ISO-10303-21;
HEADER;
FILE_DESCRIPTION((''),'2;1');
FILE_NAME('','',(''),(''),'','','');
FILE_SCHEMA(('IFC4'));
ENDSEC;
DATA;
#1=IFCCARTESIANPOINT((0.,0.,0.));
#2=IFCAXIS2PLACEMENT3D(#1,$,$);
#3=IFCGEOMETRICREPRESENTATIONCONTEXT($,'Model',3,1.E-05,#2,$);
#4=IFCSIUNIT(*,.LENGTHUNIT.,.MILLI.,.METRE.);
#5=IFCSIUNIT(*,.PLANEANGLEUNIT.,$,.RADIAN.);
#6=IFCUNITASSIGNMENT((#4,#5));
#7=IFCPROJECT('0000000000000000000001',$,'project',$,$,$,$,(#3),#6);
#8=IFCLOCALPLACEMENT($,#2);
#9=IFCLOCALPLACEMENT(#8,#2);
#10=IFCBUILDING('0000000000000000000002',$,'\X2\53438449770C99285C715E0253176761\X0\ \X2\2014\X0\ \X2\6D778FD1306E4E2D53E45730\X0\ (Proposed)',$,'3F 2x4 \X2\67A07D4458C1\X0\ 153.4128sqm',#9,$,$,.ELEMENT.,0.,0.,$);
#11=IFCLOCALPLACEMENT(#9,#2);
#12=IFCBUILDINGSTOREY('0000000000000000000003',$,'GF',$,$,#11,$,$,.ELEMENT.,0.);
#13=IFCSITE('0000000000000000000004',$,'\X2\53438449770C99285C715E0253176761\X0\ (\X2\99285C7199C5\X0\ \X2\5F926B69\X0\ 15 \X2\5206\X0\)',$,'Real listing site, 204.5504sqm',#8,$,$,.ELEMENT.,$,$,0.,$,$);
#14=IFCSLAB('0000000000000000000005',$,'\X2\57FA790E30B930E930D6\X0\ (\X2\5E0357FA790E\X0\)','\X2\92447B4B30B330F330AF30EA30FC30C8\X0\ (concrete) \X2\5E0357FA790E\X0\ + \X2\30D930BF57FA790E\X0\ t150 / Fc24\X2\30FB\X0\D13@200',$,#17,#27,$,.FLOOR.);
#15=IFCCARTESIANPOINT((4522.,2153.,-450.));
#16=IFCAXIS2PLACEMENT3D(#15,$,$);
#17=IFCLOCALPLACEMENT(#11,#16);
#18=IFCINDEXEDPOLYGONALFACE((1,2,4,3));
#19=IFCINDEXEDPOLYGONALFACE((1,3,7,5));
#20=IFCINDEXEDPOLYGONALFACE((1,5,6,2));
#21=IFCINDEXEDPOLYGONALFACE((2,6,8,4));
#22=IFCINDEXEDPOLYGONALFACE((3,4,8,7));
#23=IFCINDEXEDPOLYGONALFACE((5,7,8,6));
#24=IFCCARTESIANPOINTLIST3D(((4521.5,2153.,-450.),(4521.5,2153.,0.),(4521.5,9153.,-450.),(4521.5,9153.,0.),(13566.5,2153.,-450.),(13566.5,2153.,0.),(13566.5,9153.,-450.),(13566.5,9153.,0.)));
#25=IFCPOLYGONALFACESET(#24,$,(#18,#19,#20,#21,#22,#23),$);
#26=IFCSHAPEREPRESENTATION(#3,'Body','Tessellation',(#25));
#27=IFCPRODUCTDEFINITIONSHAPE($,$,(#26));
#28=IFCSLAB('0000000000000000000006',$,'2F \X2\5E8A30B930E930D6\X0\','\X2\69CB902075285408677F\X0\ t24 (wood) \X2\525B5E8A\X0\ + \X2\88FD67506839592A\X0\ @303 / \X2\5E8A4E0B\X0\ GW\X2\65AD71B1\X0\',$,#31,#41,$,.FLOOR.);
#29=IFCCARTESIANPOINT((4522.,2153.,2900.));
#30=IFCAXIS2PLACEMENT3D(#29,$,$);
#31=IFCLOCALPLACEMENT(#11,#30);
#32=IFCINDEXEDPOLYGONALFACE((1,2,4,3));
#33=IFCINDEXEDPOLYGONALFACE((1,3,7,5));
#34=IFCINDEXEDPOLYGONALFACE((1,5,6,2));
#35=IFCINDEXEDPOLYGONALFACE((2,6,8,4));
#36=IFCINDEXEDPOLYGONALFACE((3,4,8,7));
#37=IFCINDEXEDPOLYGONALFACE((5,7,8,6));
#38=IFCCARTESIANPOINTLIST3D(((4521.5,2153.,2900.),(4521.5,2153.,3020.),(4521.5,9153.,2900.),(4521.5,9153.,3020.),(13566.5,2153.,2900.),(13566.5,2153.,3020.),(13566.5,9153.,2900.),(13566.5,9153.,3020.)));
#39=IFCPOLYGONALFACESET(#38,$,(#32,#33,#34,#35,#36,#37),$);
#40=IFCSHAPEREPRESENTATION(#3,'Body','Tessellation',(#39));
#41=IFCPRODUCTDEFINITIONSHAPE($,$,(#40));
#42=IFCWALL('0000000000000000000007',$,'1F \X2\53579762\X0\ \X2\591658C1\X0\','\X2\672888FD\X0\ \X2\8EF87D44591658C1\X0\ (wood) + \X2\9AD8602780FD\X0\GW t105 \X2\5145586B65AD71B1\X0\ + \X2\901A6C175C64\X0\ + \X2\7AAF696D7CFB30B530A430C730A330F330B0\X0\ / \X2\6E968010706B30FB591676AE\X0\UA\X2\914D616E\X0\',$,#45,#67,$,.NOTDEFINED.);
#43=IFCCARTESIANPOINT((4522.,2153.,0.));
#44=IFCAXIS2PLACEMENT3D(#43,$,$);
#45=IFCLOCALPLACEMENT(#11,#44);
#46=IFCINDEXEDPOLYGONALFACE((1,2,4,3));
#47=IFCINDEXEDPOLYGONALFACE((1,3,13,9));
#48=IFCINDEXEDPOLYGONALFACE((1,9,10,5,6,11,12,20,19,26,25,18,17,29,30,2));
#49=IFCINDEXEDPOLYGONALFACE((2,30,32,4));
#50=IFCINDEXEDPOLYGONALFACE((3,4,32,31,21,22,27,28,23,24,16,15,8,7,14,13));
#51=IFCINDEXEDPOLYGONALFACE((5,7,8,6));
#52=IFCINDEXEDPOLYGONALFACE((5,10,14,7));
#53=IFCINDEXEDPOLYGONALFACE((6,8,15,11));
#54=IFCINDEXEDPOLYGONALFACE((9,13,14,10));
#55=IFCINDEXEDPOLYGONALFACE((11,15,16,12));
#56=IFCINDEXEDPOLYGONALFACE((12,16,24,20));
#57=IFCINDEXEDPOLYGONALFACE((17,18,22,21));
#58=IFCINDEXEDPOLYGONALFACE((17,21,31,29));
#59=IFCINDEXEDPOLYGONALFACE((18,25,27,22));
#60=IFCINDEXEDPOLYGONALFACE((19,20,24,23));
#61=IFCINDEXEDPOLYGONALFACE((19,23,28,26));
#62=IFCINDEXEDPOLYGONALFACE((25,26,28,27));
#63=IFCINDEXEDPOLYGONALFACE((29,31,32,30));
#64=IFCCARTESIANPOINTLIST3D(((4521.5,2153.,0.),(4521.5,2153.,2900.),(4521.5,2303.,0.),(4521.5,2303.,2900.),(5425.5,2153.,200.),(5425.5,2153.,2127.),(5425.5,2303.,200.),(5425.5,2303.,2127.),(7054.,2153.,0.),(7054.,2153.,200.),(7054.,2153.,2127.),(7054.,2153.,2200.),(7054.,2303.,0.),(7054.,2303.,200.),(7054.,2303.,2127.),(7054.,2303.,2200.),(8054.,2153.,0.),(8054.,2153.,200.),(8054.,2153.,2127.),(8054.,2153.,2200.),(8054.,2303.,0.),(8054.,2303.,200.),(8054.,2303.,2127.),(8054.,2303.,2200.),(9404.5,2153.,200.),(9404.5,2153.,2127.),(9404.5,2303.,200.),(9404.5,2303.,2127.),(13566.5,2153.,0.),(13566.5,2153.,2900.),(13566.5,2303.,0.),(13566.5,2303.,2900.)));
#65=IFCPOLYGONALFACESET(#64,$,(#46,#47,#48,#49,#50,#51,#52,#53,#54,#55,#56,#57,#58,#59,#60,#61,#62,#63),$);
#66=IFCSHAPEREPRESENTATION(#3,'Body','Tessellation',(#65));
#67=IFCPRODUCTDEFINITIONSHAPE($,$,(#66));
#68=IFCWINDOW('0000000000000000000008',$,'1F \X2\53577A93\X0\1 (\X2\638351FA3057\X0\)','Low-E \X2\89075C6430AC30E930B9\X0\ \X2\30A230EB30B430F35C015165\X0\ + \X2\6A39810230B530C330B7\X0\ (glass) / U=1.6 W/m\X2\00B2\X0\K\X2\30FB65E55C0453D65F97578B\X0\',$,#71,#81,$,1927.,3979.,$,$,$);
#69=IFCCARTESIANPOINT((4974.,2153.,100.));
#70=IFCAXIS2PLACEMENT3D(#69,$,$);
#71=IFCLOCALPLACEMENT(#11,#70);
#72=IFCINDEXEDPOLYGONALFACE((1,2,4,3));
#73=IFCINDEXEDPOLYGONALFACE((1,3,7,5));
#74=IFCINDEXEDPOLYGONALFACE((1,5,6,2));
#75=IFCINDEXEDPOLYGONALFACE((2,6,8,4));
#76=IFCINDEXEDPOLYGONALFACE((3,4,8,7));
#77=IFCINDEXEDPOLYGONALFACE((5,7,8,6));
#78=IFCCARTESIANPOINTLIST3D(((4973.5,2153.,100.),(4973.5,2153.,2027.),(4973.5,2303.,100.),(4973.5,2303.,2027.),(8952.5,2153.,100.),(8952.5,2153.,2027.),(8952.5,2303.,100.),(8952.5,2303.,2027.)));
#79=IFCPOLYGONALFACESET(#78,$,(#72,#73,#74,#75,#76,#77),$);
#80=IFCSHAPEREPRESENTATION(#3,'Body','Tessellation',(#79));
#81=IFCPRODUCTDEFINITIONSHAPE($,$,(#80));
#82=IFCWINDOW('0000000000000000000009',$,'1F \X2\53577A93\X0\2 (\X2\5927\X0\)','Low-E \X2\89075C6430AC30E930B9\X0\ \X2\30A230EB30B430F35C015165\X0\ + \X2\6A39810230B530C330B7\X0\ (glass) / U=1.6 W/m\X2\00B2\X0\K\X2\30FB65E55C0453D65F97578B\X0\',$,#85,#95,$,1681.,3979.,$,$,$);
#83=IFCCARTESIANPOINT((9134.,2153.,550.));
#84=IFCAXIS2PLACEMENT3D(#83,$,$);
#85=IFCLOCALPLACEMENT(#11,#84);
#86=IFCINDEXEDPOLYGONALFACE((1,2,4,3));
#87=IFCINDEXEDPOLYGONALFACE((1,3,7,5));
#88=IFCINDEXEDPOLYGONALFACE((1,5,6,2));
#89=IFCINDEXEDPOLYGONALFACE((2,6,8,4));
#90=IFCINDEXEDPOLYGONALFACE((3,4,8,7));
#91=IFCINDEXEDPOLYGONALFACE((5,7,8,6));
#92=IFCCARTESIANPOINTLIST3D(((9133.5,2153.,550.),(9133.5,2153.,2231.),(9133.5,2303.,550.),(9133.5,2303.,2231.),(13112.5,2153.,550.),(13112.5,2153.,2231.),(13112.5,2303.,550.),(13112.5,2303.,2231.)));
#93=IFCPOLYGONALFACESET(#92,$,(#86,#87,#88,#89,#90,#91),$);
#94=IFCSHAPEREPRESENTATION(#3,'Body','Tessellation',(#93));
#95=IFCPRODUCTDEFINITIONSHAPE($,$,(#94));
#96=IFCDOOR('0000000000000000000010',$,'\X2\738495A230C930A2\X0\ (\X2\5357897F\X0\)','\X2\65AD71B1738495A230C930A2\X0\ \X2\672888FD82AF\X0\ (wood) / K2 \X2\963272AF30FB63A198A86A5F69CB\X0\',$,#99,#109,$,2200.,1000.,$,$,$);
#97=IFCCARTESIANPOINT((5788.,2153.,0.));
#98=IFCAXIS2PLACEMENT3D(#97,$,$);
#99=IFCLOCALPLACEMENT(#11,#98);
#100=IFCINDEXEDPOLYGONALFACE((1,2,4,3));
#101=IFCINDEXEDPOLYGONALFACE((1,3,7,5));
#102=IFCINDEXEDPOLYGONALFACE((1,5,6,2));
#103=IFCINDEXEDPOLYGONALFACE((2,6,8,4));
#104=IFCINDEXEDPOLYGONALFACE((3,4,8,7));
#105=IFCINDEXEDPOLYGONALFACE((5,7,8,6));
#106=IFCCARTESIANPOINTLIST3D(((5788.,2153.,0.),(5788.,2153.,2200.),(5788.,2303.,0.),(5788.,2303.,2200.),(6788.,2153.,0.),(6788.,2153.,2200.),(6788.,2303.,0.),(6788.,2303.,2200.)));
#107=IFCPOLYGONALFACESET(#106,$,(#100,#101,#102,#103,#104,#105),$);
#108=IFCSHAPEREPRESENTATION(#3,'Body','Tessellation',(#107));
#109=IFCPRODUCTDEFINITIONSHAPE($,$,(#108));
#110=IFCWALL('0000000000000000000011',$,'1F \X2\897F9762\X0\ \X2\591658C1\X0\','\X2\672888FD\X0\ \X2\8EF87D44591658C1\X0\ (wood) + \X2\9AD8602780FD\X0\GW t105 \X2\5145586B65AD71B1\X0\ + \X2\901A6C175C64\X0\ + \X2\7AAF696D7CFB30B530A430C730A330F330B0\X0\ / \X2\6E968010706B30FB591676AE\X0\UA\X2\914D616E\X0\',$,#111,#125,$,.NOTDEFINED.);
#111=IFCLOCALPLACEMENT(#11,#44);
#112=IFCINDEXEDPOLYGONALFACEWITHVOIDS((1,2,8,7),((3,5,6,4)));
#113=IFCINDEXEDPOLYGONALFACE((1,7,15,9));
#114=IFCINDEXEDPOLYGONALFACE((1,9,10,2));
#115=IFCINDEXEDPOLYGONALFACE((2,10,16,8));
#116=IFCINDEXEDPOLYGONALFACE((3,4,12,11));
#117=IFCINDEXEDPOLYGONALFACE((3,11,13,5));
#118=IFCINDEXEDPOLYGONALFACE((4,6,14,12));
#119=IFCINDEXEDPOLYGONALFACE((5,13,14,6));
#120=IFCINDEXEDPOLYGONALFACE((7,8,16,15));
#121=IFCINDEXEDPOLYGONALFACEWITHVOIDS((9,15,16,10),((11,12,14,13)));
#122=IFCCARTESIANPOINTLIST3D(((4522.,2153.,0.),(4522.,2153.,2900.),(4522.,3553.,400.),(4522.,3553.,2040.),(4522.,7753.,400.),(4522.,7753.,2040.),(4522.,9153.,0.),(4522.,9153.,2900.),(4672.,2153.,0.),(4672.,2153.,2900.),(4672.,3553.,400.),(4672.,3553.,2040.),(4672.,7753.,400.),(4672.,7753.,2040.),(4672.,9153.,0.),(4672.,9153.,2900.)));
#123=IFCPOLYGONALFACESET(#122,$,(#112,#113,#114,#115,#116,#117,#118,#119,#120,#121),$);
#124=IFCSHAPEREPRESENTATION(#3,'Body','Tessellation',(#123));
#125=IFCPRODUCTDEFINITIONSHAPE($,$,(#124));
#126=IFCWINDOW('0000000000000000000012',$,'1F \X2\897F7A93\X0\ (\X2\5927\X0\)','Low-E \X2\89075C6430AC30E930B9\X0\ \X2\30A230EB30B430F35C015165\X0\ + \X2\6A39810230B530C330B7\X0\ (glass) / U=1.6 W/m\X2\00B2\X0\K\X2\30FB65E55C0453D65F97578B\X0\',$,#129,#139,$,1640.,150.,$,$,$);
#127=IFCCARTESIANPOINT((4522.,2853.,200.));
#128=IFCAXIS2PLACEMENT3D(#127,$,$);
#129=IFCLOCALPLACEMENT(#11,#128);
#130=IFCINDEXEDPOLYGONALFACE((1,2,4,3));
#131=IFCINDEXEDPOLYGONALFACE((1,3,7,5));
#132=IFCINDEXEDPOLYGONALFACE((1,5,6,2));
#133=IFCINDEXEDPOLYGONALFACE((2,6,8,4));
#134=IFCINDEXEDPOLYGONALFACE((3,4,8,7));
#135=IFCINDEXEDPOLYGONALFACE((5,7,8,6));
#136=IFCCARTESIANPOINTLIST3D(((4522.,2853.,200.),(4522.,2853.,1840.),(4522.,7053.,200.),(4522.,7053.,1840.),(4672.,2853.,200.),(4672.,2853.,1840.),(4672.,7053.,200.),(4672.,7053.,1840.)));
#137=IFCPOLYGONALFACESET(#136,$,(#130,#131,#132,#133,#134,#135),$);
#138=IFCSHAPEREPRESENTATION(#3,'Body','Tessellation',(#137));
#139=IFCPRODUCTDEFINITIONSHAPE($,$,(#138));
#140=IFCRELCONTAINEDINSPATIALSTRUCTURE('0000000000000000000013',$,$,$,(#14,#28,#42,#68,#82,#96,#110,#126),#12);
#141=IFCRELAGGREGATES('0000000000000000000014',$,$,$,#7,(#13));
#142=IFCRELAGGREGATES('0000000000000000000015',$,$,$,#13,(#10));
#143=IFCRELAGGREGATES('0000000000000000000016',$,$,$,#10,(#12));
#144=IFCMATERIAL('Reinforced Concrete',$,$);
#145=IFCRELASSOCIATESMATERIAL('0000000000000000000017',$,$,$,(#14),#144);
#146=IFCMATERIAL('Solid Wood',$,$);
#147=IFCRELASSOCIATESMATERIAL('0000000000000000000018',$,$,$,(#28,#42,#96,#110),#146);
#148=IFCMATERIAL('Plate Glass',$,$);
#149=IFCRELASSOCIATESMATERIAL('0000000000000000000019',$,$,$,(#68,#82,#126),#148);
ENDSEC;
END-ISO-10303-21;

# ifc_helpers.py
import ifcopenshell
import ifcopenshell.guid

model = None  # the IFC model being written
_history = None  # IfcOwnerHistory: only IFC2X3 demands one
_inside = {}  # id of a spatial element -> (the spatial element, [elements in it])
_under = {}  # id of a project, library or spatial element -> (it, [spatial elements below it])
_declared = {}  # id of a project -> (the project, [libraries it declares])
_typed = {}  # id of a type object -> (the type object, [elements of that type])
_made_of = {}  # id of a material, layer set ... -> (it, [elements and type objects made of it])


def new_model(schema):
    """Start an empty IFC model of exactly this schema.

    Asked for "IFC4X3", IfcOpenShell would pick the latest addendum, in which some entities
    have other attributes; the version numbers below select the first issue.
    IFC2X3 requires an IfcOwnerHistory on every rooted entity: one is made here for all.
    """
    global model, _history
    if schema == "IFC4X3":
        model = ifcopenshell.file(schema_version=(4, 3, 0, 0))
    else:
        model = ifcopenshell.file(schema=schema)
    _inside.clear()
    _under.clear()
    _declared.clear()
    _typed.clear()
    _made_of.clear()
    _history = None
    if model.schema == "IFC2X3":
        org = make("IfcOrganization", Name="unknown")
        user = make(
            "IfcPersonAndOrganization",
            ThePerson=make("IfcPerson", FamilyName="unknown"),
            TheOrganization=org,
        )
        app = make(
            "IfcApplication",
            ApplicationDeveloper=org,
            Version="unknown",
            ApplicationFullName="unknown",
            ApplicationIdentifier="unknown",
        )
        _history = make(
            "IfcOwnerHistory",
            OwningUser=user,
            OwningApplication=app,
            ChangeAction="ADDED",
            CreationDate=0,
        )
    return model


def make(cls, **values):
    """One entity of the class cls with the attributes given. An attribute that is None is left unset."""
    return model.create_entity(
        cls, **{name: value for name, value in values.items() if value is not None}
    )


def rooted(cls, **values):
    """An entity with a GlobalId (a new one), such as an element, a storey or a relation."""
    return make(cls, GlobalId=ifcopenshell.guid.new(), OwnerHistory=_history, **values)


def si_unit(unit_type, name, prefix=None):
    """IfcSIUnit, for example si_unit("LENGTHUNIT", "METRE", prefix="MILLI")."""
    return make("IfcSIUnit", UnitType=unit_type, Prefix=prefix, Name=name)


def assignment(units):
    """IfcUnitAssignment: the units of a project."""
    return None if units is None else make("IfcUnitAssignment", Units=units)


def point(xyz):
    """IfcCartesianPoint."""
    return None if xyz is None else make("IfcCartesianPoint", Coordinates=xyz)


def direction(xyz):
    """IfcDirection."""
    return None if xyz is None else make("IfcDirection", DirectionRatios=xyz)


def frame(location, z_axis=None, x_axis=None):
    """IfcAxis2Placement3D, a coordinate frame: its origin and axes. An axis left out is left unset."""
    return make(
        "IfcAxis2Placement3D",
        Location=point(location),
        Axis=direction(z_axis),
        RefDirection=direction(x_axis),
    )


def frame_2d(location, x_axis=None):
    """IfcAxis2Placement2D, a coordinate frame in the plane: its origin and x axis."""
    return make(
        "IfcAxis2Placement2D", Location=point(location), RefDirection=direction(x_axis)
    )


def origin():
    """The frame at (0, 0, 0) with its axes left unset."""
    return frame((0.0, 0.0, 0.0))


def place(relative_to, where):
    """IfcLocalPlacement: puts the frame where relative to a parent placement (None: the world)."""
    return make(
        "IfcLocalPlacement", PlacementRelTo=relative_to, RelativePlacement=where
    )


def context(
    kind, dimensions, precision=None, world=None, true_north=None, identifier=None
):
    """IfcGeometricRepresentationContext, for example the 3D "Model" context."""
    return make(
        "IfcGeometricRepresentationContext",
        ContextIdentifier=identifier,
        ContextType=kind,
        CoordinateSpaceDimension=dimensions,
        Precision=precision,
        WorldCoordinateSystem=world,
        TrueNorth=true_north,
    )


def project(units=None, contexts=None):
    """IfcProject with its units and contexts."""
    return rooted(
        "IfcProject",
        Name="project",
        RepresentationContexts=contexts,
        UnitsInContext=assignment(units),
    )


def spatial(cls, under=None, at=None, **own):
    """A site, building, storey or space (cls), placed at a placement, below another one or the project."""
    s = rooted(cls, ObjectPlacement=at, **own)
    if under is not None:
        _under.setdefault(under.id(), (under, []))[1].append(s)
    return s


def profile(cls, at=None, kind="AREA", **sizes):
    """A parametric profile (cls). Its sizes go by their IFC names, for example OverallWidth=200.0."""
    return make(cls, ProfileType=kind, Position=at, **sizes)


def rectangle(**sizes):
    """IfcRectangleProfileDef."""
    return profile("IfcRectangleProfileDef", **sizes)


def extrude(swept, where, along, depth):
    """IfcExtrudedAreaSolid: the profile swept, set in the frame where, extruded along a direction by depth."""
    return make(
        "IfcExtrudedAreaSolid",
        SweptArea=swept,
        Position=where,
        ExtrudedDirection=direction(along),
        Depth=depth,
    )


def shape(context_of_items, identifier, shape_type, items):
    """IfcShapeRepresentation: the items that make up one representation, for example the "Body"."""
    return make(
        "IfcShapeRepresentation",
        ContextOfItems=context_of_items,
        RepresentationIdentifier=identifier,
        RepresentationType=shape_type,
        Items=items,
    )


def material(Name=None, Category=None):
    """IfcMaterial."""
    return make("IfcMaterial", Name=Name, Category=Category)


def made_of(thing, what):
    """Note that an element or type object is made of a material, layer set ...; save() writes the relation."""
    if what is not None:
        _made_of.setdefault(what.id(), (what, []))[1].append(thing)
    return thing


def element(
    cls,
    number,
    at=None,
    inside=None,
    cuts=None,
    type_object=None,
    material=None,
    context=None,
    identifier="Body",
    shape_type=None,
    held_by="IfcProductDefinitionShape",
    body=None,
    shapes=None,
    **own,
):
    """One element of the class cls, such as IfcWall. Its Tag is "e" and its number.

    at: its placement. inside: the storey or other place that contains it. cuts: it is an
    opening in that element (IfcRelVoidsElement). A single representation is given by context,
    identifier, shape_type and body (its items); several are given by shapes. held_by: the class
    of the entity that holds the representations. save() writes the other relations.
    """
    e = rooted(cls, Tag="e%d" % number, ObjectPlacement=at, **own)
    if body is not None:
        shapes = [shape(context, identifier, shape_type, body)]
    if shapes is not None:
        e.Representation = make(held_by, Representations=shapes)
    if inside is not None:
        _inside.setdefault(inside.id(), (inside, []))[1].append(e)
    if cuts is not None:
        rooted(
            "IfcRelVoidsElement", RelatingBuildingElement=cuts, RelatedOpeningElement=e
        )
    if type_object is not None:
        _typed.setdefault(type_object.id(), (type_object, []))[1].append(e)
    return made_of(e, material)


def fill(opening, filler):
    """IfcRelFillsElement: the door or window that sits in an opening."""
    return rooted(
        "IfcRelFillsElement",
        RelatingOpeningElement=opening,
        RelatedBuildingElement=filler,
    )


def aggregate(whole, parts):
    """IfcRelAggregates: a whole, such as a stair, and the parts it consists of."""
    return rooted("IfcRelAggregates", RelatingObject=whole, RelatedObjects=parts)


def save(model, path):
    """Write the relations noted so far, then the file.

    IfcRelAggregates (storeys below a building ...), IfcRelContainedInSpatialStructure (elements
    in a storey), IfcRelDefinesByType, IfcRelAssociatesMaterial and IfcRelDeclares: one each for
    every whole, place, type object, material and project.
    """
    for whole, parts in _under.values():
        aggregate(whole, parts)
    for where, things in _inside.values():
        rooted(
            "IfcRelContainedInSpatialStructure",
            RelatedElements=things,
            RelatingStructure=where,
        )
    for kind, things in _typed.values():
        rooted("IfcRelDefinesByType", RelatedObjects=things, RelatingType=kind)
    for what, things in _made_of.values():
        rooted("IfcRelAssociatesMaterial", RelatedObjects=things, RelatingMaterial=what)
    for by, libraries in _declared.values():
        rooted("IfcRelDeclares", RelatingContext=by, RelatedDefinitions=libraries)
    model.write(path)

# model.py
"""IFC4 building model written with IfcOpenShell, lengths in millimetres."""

from ifc_helpers import new_model, si_unit, frame, frame_2d, origin, place, context, project, spatial, rectangle, extrude, material, element, fill, save


model = new_model("IFC4")

# Units and contexts
model_context = context("Model", 3, precision=1e-05, world=origin())
ifc_project = project(units=[si_unit("LENGTHUNIT", "METRE", prefix="MILLI"), si_unit("PLANEANGLEUNIT", "RADIAN")], contexts=[model_context])

# Site, building, storey
site_placement = place(None, origin())
site = spatial("IfcSite", under=ifc_project, at=site_placement, Name="千葉県館山市北条 (館山駅 徒歩 15 分)", ObjectType="Real listing site, 204.5504sqm", CompositionType="ELEMENT", RefElevation=0.0)
building_placement = place(site_placement, origin())
building = spatial("IfcBuilding", under=site, at=building_placement, Name="千葉県館山市北条 — 海近の中古地 (Proposed)", ObjectType="3F 2x4 枠組壁 153.4128sqm", CompositionType="ELEMENT", ElevationOfRefHeight=0.0, ElevationOfTerrain=0.0)
storey_placement = place(building_placement, origin())
storey = spatial("IfcBuildingStorey", under=building, at=storey_placement, Name="GF", CompositionType="ELEMENT", Elevation=0.0)

# Slabs
ifc_material_1 = material(Name="Reinforced Concrete")
slab_1_placement = place(storey_placement, frame((4522.0, 2153.0, -450.0)))
element("IfcSlab", 1, at=slab_1_placement, inside=storey, material=ifc_material_1, Name="基礎スラブ (布基礎)", Description="鉄筋コンクリート (concrete) 布基礎 + ベタ基礎 t150 / Fc24・D13@200", PredefinedType="FLOOR", context=model_context, shape_type="SweptSolid", body=[
    extrude(rectangle(XDim=9045.0, YDim=7000.0, at=frame_2d((4522.0, 3500.0))), frame((4522.0, 2153.0, -450.0)), (0.0, 0.0, 1.0), 450.0),
])
ifc_material_2 = material(Name="Solid Wood")
slab_2_placement = place(storey_placement, frame((4522.0, 2153.0, 2900.0)))
element("IfcSlab", 2, at=slab_2_placement, inside=storey, material=ifc_material_2, Name="2F 床スラブ", Description="構造用合板 t24 (wood) 剛床 + 製材根太 @303 / 床下 GW断熱", PredefinedType="FLOOR", context=model_context, shape_type="SweptSolid", body=[
    extrude(rectangle(XDim=9045.0, YDim=7000.0, at=frame_2d((4522.0, 3500.0))), frame((4522.0, 2153.0, 2900.0)), (0.0, 0.0, 1.0), 120.0),
])

# Wall, openings, windows, door
wall_1_placement = place(storey_placement, frame((4522.0, 2153.0, 0.0)))
wall_1 = element("IfcWall", 3, at=wall_1_placement, inside=storey, material=ifc_material_2, Name="1F 南面 外壁", Description="木製 軸組外壁 (wood) + 高性能GW t105 充填断熱 + 通気層 + 窯業系サイディング / 準耐火・外皮UA配慮", PredefinedType="NOTDEFINED", context=model_context, shape_type="SweptSolid", body=[
    extrude(rectangle(XDim=9045.0, YDim=150.0, at=frame_2d((4522.0, 75.0))), frame((4522.0, 2153.0, 0.0)), (0.0, 0.0, 1.0), 2900.0),
])
opening_1_placement = place(storey_placement, frame((4974.0, 2153.0, 100.0)))
opening_1 = element("IfcOpeningElement", 4, at=opening_1_placement, cuts=wall_1, PredefinedType="NOTDEFINED", context=model_context, shape_type="SweptSolid", body=[
    extrude(rectangle(XDim=3979.0, YDim=150.0, at=frame_2d((1989.0, 75.0))), frame((4974.0, 2153.0, 100.0)), (0.0, 0.0, 1.0), 1927.0),
])
opening_2_placement = place(storey_placement, frame((9134.0, 2153.0, 550.0)))
opening_2 = element("IfcOpeningElement", 5, at=opening_2_placement, cuts=wall_1, PredefinedType="NOTDEFINED", context=model_context, shape_type="SweptSolid", body=[
    extrude(rectangle(XDim=3979.0, YDim=150.0, at=frame_2d((1989.0, 75.0))), frame((9134.0, 2153.0, 550.0)), (0.0, 0.0, 1.0), 1681.0),
])
opening_3_placement = place(storey_placement, frame((5788.0, 2153.0, 0.0)))
opening_3 = element("IfcOpeningElement", 6, at=opening_3_placement, cuts=wall_1, PredefinedType="NOTDEFINED", context=model_context, shape_type="SweptSolid", body=[
    extrude(rectangle(XDim=1000.0, YDim=150.0, at=frame_2d((500.0, 75.0))), frame((5788.0, 2153.0, 0.0)), (0.0, 0.0, 1.0), 2200.0),
])
ifc_material_3 = material(Name="Plate Glass")
window_1_placement = place(storey_placement, frame((4974.0, 2153.0, 100.0)))
window_1 = element("IfcWindow", 7, at=window_1_placement, inside=storey, material=ifc_material_3, Name="1F 南窓1 (掃出し)", Description="Low-E 複層ガラス アルゴン封入 + 樹脂サッシ (glass) / U=1.6 W/m²K・日射取得型", OverallHeight=1927.0, OverallWidth=3979.0, context=model_context, shape_type="SweptSolid", body=[
    extrude(rectangle(XDim=3979.0, YDim=150.0, at=frame_2d((1989.0, 75.0))), frame((4974.0, 2153.0, 100.0)), (0.0, 0.0, 1.0), 1927.0),
])
fill(opening_1, window_1)
window_2_placement = place(storey_placement, frame((9134.0, 2153.0, 550.0)))
window_2 = element("IfcWindow", 8, at=window_2_placement, inside=storey, material=ifc_material_3, Name="1F 南窓2 (大)", Description="Low-E 複層ガラス アルゴン封入 + 樹脂サッシ (glass) / U=1.6 W/m²K・日射取得型", OverallHeight=1681.0, OverallWidth=3979.0, context=model_context, shape_type="SweptSolid", body=[
    extrude(rectangle(XDim=3979.0, YDim=150.0, at=frame_2d((1989.0, 75.0))), frame((9134.0, 2153.0, 550.0)), (0.0, 0.0, 1.0), 1681.0),
])
fill(opening_2, window_2)
door_placement = place(storey_placement, frame((5788.0, 2153.0, 0.0)))
door = element("IfcDoor", 9, at=door_placement, inside=storey, material=ifc_material_2, Name="玄関ドア (南西)", Description="断熱玄関ドア 木製芯 (wood) / K2 防犯・採風機構", OverallHeight=2200.0, OverallWidth=1000.0, context=model_context, shape_type="SweptSolid", body=[
    extrude(rectangle(XDim=1000.0, YDim=150.0, at=frame_2d((500.0, 75.0))), frame((5788.0, 2153.0, 0.0)), (0.0, 0.0, 1.0), 2200.0),
])
fill(opening_3, door)

# Wall, opening, window
wall_2_placement = place(storey_placement, frame((4522.0, 2153.0, 0.0)))
wall_2 = element("IfcWall", 10, at=wall_2_placement, inside=storey, material=ifc_material_2, Name="1F 西面 外壁", Description="木製 軸組外壁 (wood) + 高性能GW t105 充填断熱 + 通気層 + 窯業系サイディング / 準耐火・外皮UA配慮", PredefinedType="NOTDEFINED", context=model_context, shape_type="SweptSolid", body=[
    extrude(rectangle(XDim=150.0, YDim=7000.0, at=frame_2d((75.0, 3500.0))), frame((4522.0, 2153.0, 0.0)), (0.0, 0.0, 1.0), 2900.0),
])
opening_4_placement = place(storey_placement, frame((4522.0, 2853.0, 200.0)))
opening_4 = element("IfcOpeningElement", 11, at=opening_4_placement, cuts=wall_2, PredefinedType="NOTDEFINED", context=model_context, shape_type="SweptSolid", body=[
    extrude(rectangle(XDim=150.0, YDim=4200.0, at=frame_2d((75.0, 2100.0))), frame((4522.0, 2853.0, 200.0)), (0.0, 0.0, 1.0), 1640.0),
])
window_3_placement = place(storey_placement, frame((4522.0, 2853.0, 200.0)))
window_3 = element("IfcWindow", 12, at=window_3_placement, inside=storey, material=ifc_material_3, Name="1F 西窓 (大)", Description="Low-E 複層ガラス アルゴン封入 + 樹脂サッシ (glass) / U=1.6 W/m²K・日射取得型", OverallHeight=1640.0, OverallWidth=150.0, context=model_context, shape_type="SweptSolid", body=[
    extrude(rectangle(XDim=150.0, YDim=4200.0, at=frame_2d((75.0, 2100.0))), frame((4522.0, 2853.0, 200.0)), (0.0, 0.0, 1.0), 1640.0),
])
fill(opening_4, window_3)

save(model, "model.ifc")
